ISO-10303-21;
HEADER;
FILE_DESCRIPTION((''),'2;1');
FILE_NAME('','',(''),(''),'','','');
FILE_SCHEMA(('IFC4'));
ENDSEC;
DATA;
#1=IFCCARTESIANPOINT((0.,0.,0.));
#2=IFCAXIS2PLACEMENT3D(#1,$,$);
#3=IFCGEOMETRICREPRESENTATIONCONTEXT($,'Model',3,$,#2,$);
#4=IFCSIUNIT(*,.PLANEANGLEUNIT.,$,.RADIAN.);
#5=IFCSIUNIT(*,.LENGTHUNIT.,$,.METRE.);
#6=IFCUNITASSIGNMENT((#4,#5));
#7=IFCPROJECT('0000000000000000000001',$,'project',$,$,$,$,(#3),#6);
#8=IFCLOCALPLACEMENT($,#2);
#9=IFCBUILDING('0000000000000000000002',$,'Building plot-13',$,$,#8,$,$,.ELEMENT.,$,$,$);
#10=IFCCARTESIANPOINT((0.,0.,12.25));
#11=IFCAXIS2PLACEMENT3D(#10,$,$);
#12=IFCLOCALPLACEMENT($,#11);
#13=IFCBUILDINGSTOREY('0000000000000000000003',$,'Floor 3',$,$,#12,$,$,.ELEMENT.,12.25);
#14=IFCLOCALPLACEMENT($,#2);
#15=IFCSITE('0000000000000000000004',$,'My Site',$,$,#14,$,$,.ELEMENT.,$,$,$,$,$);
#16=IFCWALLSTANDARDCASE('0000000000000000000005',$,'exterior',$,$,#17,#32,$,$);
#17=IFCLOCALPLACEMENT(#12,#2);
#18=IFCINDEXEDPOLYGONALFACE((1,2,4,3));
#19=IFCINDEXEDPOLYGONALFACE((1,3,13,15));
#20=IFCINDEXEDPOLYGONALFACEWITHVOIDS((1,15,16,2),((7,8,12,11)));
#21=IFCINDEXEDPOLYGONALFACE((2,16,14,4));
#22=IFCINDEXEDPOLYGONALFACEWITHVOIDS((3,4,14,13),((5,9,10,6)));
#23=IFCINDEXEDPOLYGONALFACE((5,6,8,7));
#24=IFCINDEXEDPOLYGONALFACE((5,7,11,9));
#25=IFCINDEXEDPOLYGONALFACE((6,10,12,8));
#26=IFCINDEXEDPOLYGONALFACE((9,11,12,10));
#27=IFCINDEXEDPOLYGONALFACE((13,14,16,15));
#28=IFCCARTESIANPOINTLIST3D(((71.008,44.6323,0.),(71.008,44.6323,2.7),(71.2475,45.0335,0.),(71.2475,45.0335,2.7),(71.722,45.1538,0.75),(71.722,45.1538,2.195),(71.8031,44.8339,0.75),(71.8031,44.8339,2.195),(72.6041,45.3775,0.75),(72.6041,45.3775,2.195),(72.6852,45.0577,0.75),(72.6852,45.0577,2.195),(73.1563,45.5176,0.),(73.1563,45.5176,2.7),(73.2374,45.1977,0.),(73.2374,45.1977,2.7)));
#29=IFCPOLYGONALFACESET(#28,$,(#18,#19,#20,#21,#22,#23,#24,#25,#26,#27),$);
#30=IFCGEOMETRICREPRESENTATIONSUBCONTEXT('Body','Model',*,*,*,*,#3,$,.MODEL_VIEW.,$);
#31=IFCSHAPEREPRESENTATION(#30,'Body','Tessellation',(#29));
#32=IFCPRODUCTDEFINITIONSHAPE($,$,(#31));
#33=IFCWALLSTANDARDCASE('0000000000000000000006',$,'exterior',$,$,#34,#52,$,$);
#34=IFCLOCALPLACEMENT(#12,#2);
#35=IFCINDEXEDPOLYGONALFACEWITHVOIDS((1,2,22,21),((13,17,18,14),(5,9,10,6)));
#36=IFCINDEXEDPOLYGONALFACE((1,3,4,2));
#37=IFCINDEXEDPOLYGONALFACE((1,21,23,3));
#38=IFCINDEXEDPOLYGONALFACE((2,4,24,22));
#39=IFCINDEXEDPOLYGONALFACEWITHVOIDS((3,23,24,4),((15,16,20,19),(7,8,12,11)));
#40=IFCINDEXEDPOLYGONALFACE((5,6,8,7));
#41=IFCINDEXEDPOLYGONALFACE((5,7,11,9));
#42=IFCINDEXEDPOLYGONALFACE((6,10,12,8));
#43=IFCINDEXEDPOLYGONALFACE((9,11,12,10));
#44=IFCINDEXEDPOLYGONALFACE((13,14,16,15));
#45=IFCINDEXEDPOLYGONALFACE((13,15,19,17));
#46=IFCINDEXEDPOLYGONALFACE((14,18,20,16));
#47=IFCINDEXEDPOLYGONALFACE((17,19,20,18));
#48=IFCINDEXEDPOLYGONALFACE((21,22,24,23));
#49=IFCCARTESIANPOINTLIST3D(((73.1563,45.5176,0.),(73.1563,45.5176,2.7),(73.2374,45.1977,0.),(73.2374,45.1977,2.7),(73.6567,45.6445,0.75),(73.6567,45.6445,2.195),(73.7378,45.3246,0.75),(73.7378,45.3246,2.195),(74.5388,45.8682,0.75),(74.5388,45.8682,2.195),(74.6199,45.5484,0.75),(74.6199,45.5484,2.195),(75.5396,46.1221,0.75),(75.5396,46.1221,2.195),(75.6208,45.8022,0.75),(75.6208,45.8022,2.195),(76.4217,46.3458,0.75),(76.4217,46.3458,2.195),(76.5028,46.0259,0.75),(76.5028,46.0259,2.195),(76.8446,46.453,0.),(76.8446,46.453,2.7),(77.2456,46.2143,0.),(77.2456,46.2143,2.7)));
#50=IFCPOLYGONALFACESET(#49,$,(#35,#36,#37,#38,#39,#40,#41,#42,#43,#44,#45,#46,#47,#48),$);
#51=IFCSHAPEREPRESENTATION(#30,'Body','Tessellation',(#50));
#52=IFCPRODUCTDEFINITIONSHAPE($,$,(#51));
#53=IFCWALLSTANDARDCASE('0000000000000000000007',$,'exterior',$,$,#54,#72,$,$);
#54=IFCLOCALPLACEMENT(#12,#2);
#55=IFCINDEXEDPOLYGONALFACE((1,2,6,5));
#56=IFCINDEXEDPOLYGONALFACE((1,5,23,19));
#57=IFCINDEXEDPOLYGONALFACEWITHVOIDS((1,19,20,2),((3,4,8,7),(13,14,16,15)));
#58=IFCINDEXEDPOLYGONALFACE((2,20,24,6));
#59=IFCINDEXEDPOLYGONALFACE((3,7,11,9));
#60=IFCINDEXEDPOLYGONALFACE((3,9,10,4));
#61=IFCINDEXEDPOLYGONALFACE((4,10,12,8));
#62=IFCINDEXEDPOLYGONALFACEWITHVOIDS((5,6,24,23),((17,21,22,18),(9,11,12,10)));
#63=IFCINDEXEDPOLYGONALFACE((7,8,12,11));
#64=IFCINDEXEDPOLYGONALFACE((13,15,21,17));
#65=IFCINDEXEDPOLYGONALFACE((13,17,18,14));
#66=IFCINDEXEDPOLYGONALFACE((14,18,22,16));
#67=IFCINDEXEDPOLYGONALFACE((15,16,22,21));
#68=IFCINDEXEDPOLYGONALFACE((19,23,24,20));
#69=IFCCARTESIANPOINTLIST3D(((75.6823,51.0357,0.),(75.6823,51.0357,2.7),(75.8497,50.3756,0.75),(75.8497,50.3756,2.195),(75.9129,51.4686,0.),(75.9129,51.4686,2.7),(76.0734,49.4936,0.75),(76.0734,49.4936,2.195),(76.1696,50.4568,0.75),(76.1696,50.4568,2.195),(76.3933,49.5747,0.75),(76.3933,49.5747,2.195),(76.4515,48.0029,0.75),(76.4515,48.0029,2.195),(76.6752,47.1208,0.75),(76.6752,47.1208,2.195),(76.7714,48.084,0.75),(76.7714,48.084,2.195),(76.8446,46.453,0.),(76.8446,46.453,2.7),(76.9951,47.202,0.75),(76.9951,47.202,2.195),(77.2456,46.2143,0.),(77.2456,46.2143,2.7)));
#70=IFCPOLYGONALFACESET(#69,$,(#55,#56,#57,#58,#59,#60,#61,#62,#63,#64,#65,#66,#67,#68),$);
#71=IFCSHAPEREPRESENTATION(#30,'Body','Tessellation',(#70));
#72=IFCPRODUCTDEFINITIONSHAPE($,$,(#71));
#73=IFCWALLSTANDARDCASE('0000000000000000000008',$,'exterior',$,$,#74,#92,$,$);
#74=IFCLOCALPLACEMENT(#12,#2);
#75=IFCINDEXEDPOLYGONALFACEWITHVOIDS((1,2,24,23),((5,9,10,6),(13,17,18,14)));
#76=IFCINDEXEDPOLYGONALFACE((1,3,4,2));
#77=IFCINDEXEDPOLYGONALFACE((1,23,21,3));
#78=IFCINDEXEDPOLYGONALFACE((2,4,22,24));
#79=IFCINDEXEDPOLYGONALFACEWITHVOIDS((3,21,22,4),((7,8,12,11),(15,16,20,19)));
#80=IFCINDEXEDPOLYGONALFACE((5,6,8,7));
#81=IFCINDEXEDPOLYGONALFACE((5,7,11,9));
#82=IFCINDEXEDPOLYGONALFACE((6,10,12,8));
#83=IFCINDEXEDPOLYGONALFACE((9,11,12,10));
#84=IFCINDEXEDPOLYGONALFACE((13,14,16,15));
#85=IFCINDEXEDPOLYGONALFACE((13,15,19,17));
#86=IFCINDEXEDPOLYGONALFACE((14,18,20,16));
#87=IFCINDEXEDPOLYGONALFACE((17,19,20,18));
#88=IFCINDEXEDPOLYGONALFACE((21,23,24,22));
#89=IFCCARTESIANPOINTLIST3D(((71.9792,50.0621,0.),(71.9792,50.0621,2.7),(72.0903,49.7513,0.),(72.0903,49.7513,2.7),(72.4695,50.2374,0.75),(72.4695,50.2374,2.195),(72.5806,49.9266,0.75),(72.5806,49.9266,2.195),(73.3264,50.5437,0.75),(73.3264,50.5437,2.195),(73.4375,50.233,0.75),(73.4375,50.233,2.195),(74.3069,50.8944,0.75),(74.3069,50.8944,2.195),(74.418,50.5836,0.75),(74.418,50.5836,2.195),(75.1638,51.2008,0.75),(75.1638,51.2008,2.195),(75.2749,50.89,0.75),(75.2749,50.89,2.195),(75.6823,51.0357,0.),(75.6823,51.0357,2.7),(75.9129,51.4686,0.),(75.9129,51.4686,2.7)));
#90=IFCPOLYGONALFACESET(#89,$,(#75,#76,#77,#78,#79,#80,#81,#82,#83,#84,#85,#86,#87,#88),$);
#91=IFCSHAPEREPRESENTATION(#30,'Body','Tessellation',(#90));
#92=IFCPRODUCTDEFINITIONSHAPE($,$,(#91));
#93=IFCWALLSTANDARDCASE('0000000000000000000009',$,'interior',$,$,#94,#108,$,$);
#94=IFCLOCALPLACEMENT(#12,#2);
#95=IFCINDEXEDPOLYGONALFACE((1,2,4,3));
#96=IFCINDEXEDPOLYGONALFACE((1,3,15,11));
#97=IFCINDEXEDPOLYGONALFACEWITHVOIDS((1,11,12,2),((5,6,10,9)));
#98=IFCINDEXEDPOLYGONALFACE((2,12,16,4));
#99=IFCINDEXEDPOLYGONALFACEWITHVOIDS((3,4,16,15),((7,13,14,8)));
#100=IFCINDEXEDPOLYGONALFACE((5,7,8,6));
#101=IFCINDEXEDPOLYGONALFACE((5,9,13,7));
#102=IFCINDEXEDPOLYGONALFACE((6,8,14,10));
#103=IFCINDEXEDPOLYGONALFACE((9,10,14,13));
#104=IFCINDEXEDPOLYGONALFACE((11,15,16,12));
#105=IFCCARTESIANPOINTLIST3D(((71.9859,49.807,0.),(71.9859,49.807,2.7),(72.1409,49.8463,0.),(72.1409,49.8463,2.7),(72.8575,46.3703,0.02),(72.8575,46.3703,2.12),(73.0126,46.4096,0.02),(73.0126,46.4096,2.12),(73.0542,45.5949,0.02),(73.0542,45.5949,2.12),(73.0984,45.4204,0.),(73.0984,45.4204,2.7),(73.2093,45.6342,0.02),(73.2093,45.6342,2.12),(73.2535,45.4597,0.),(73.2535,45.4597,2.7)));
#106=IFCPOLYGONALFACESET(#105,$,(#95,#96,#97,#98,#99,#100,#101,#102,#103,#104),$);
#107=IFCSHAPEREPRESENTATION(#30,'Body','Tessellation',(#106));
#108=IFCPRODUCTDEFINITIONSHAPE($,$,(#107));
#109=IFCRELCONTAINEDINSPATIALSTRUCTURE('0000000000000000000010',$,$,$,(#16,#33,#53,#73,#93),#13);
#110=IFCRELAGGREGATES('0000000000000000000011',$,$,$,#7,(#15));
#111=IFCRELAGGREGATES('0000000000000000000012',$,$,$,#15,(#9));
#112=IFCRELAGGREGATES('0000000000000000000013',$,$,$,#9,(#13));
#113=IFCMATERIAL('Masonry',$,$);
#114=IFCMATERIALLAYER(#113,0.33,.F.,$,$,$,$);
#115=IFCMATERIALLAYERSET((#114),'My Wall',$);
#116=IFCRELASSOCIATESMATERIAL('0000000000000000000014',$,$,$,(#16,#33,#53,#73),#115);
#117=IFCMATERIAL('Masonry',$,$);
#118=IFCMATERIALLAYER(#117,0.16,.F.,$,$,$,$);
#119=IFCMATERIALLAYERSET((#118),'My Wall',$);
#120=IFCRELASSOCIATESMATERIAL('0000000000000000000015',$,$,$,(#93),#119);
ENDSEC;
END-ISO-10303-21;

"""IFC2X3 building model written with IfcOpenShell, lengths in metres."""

from ifc_helpers import new_model, si_unit, frame, origin, place, context, subcontext, project, spatial, polyline, outline, extrude, material, layer, layer_set, layer_usage, element, save


model = new_model("IFC2X3")

# Units and contexts
model_context = context("Model", 3, world=origin())
body_context = subcontext(model_context, "Body", "Model", "MODEL_VIEW")
ifc_project = project(units=[si_unit("PLANEANGLEUNIT", "RADIAN"), si_unit("LENGTHUNIT", "METRE")], contexts=[model_context])

# Site, building, storey
site_placement = place(None, origin())
site = spatial("IfcSite", under=ifc_project, at=site_placement, Name="My Site", CompositionType="ELEMENT")
building_placement = place(None, origin())
building = spatial("IfcBuilding", under=site, at=building_placement, Name="Building plot-13", CompositionType="ELEMENT")
storey_placement = place(None, frame((0.0, 0.0, 12.25)))
storey = spatial("IfcBuildingStorey", under=building, at=storey_placement, Name="Floor 3", CompositionType="ELEMENT", Elevation=12.25)

# Shared definitions
ifc_material_1 = material(Name="Masonry")
ifc_layer_1 = layer(ifc_material_1, 0.33, ventilated=False)
ifc_layer_set_1 = layer_set([ifc_layer_1], Name="My Wall")
ifc_layer_usage_1 = layer_usage(ifc_layer_set_1, "AXIS2", "NEGATIVE", 0.08)

# Wall, opening
wall_1_placement = place(storey_placement, origin())
wall_1 = element("IfcWallStandardCase", 1, at=wall_1_placement, inside=storey, material=ifc_layer_usage_1, Name="exterior", context=body_context, shape_type="SweptSolid", body=[
    extrude(outline(polyline([(71.2475, 45.0335), (71.008, 44.6323), (73.2374, 45.1977), (73.1563, 45.5176), (71.2475, 45.0335)])), origin(), (0.0, 0.0, 1.0), 2.7),
])
opening_1_placement = place(storey_placement, frame((0.0, 0.0, 0.75)))
element("IfcOpeningElement", 2, at=opening_1_placement, cuts=wall_1, ObjectType="Opening", context=body_context, shape_type="SweptSolid", body=[
    extrude(outline(polyline([(71.8031, 44.8339), (72.6852, 45.0577), (72.6041, 45.3775), (71.722, 45.1538), (71.8031, 44.8339)])), origin(), (0.0, 0.0, 1.0), 1.445),
])

# Walls, openings
wall_2_placement = place(storey_placement, origin())
wall_2 = element("IfcWallStandardCase", 3, at=wall_2_placement, inside=storey, material=ifc_layer_usage_1, Name="exterior", context=body_context, shape_type="SweptSolid", body=[
    extrude(outline(polyline([(73.1563, 45.5176), (73.2374, 45.1977), (77.2456, 46.2143), (76.8446, 46.453), (73.1563, 45.5176)])), origin(), (0.0, 0.0, 1.0), 2.7),
])
opening_2_placement = place(storey_placement, frame((0.0, 0.0, 0.75)))
element("IfcOpeningElement", 4, at=opening_2_placement, cuts=wall_2, ObjectType="Opening", context=body_context, shape_type="SweptSolid", body=[
    extrude(outline(polyline([(73.7378, 45.3246), (74.6199, 45.5484), (74.5388, 45.8682), (73.6567, 45.6445), (73.7378, 45.3246)])), origin(), (0.0, 0.0, 1.0), 1.445),
])
opening_3_placement = place(storey_placement, frame((0.0, 0.0, 0.75)))
element("IfcOpeningElement", 5, at=opening_3_placement, cuts=wall_2, ObjectType="Opening", context=body_context, shape_type="SweptSolid", body=[
    extrude(outline(polyline([(75.6208, 45.8022), (76.5028, 46.0259), (76.4217, 46.3458), (75.5396, 46.1221), (75.6208, 45.8022)])), origin(), (0.0, 0.0, 1.0), 1.445),
])
wall_3_placement = place(storey_placement, origin())
wall_3 = element("IfcWallStandardCase", 6, at=wall_3_placement, inside=storey, material=ifc_layer_usage_1, Name="exterior", context=body_context, shape_type="SweptSolid", body=[
    extrude(outline(polyline([(76.8446, 46.453), (77.2456, 46.2143), (75.9129, 51.4686), (75.6823, 51.0357), (76.8446, 46.453)])), origin(), (0.0, 0.0, 1.0), 2.7),
])
opening_4_placement = place(storey_placement, frame((0.0, 0.0, 0.75)))
element("IfcOpeningElement", 7, at=opening_4_placement, cuts=wall_3, ObjectType="Opening", context=body_context, shape_type="SweptSolid", body=[
    extrude(outline(polyline([(76.9951, 47.202), (76.7714, 48.084), (76.4515, 48.0029), (76.6752, 47.1208), (76.9951, 47.202)])), origin(), (0.0, 0.0, 1.0), 1.445),
])
opening_5_placement = place(storey_placement, frame((0.0, 0.0, 0.75)))
element("IfcOpeningElement", 8, at=opening_5_placement, cuts=wall_3, ObjectType="Opening", context=body_context, shape_type="SweptSolid", body=[
    extrude(outline(polyline([(76.3933, 49.5747), (76.1696, 50.4568), (75.8497, 50.3756), (76.0734, 49.4936), (76.3933, 49.5747)])), origin(), (0.0, 0.0, 1.0), 1.445),
])
wall_4_placement = place(storey_placement, origin())
wall_4 = element("IfcWallStandardCase", 9, at=wall_4_placement, inside=storey, material=ifc_layer_usage_1, Name="exterior", context=body_context, shape_type="SweptSolid", body=[
    extrude(outline(polyline([(75.6823, 51.0357), (75.9129, 51.4686), (71.9792, 50.0621), (72.0903, 49.7513), (75.6823, 51.0357)])), origin(), (0.0, 0.0, 1.0), 2.7),
])
opening_6_placement = place(storey_placement, frame((0.0, 0.0, 0.75)))
element("IfcOpeningElement", 10, at=opening_6_placement, cuts=wall_4, ObjectType="Opening", context=body_context, shape_type="SweptSolid", body=[
    extrude(outline(polyline([(75.1638, 51.2008), (74.3069, 50.8944), (74.418, 50.5836), (75.2749, 50.89), (75.1638, 51.2008)])), origin(), (0.0, 0.0, 1.0), 1.445),
])
opening_7_placement = place(storey_placement, frame((0.0, 0.0, 0.75)))
element("IfcOpeningElement", 11, at=opening_7_placement, cuts=wall_4, ObjectType="Opening", context=body_context, shape_type="SweptSolid", body=[
    extrude(outline(polyline([(73.3264, 50.5437), (72.4695, 50.2374), (72.5806, 49.9266), (73.4375, 50.233), (73.3264, 50.5437)])), origin(), (0.0, 0.0, 1.0), 1.445),
])

# Wall, opening
ifc_material_2 = material(Name="Masonry")
ifc_layer_2 = layer(ifc_material_2, 0.16, ventilated=False)
ifc_layer_set_2 = layer_set([ifc_layer_2], Name="My Wall")
ifc_layer_usage_2 = layer_usage(ifc_layer_set_2, "AXIS2", "NEGATIVE", 0.08)
wall_5_placement = place(storey_placement, origin())
wall_5 = element("IfcWallStandardCase", 12, at=wall_5_placement, inside=storey, material=ifc_layer_usage_2, Name="interior", context=body_context, shape_type="SweptSolid", body=[
    extrude(outline(polyline([(72.1409, 49.8463), (71.9859, 49.807), (73.0984, 45.4204), (73.2535, 45.4597), (72.1409, 49.8463)])), origin(), (0.0, 0.0, 1.0), 2.7),
])
opening_8_placement = place(storey_placement, frame((0.0, 0.0, 0.02)))
element("IfcOpeningElement", 13, at=opening_8_placement, cuts=wall_5, ObjectType="Opening", context=body_context, shape_type="SweptSolid", body=[
    extrude(outline(polyline([(72.8575, 46.3703), (73.0542, 45.5949), (73.2093, 45.6342), (73.0126, 46.4096), (72.8575, 46.3703)])), origin(), (0.0, 0.0, 1.0), 2.1),
])

save(model, "model.ifc")
